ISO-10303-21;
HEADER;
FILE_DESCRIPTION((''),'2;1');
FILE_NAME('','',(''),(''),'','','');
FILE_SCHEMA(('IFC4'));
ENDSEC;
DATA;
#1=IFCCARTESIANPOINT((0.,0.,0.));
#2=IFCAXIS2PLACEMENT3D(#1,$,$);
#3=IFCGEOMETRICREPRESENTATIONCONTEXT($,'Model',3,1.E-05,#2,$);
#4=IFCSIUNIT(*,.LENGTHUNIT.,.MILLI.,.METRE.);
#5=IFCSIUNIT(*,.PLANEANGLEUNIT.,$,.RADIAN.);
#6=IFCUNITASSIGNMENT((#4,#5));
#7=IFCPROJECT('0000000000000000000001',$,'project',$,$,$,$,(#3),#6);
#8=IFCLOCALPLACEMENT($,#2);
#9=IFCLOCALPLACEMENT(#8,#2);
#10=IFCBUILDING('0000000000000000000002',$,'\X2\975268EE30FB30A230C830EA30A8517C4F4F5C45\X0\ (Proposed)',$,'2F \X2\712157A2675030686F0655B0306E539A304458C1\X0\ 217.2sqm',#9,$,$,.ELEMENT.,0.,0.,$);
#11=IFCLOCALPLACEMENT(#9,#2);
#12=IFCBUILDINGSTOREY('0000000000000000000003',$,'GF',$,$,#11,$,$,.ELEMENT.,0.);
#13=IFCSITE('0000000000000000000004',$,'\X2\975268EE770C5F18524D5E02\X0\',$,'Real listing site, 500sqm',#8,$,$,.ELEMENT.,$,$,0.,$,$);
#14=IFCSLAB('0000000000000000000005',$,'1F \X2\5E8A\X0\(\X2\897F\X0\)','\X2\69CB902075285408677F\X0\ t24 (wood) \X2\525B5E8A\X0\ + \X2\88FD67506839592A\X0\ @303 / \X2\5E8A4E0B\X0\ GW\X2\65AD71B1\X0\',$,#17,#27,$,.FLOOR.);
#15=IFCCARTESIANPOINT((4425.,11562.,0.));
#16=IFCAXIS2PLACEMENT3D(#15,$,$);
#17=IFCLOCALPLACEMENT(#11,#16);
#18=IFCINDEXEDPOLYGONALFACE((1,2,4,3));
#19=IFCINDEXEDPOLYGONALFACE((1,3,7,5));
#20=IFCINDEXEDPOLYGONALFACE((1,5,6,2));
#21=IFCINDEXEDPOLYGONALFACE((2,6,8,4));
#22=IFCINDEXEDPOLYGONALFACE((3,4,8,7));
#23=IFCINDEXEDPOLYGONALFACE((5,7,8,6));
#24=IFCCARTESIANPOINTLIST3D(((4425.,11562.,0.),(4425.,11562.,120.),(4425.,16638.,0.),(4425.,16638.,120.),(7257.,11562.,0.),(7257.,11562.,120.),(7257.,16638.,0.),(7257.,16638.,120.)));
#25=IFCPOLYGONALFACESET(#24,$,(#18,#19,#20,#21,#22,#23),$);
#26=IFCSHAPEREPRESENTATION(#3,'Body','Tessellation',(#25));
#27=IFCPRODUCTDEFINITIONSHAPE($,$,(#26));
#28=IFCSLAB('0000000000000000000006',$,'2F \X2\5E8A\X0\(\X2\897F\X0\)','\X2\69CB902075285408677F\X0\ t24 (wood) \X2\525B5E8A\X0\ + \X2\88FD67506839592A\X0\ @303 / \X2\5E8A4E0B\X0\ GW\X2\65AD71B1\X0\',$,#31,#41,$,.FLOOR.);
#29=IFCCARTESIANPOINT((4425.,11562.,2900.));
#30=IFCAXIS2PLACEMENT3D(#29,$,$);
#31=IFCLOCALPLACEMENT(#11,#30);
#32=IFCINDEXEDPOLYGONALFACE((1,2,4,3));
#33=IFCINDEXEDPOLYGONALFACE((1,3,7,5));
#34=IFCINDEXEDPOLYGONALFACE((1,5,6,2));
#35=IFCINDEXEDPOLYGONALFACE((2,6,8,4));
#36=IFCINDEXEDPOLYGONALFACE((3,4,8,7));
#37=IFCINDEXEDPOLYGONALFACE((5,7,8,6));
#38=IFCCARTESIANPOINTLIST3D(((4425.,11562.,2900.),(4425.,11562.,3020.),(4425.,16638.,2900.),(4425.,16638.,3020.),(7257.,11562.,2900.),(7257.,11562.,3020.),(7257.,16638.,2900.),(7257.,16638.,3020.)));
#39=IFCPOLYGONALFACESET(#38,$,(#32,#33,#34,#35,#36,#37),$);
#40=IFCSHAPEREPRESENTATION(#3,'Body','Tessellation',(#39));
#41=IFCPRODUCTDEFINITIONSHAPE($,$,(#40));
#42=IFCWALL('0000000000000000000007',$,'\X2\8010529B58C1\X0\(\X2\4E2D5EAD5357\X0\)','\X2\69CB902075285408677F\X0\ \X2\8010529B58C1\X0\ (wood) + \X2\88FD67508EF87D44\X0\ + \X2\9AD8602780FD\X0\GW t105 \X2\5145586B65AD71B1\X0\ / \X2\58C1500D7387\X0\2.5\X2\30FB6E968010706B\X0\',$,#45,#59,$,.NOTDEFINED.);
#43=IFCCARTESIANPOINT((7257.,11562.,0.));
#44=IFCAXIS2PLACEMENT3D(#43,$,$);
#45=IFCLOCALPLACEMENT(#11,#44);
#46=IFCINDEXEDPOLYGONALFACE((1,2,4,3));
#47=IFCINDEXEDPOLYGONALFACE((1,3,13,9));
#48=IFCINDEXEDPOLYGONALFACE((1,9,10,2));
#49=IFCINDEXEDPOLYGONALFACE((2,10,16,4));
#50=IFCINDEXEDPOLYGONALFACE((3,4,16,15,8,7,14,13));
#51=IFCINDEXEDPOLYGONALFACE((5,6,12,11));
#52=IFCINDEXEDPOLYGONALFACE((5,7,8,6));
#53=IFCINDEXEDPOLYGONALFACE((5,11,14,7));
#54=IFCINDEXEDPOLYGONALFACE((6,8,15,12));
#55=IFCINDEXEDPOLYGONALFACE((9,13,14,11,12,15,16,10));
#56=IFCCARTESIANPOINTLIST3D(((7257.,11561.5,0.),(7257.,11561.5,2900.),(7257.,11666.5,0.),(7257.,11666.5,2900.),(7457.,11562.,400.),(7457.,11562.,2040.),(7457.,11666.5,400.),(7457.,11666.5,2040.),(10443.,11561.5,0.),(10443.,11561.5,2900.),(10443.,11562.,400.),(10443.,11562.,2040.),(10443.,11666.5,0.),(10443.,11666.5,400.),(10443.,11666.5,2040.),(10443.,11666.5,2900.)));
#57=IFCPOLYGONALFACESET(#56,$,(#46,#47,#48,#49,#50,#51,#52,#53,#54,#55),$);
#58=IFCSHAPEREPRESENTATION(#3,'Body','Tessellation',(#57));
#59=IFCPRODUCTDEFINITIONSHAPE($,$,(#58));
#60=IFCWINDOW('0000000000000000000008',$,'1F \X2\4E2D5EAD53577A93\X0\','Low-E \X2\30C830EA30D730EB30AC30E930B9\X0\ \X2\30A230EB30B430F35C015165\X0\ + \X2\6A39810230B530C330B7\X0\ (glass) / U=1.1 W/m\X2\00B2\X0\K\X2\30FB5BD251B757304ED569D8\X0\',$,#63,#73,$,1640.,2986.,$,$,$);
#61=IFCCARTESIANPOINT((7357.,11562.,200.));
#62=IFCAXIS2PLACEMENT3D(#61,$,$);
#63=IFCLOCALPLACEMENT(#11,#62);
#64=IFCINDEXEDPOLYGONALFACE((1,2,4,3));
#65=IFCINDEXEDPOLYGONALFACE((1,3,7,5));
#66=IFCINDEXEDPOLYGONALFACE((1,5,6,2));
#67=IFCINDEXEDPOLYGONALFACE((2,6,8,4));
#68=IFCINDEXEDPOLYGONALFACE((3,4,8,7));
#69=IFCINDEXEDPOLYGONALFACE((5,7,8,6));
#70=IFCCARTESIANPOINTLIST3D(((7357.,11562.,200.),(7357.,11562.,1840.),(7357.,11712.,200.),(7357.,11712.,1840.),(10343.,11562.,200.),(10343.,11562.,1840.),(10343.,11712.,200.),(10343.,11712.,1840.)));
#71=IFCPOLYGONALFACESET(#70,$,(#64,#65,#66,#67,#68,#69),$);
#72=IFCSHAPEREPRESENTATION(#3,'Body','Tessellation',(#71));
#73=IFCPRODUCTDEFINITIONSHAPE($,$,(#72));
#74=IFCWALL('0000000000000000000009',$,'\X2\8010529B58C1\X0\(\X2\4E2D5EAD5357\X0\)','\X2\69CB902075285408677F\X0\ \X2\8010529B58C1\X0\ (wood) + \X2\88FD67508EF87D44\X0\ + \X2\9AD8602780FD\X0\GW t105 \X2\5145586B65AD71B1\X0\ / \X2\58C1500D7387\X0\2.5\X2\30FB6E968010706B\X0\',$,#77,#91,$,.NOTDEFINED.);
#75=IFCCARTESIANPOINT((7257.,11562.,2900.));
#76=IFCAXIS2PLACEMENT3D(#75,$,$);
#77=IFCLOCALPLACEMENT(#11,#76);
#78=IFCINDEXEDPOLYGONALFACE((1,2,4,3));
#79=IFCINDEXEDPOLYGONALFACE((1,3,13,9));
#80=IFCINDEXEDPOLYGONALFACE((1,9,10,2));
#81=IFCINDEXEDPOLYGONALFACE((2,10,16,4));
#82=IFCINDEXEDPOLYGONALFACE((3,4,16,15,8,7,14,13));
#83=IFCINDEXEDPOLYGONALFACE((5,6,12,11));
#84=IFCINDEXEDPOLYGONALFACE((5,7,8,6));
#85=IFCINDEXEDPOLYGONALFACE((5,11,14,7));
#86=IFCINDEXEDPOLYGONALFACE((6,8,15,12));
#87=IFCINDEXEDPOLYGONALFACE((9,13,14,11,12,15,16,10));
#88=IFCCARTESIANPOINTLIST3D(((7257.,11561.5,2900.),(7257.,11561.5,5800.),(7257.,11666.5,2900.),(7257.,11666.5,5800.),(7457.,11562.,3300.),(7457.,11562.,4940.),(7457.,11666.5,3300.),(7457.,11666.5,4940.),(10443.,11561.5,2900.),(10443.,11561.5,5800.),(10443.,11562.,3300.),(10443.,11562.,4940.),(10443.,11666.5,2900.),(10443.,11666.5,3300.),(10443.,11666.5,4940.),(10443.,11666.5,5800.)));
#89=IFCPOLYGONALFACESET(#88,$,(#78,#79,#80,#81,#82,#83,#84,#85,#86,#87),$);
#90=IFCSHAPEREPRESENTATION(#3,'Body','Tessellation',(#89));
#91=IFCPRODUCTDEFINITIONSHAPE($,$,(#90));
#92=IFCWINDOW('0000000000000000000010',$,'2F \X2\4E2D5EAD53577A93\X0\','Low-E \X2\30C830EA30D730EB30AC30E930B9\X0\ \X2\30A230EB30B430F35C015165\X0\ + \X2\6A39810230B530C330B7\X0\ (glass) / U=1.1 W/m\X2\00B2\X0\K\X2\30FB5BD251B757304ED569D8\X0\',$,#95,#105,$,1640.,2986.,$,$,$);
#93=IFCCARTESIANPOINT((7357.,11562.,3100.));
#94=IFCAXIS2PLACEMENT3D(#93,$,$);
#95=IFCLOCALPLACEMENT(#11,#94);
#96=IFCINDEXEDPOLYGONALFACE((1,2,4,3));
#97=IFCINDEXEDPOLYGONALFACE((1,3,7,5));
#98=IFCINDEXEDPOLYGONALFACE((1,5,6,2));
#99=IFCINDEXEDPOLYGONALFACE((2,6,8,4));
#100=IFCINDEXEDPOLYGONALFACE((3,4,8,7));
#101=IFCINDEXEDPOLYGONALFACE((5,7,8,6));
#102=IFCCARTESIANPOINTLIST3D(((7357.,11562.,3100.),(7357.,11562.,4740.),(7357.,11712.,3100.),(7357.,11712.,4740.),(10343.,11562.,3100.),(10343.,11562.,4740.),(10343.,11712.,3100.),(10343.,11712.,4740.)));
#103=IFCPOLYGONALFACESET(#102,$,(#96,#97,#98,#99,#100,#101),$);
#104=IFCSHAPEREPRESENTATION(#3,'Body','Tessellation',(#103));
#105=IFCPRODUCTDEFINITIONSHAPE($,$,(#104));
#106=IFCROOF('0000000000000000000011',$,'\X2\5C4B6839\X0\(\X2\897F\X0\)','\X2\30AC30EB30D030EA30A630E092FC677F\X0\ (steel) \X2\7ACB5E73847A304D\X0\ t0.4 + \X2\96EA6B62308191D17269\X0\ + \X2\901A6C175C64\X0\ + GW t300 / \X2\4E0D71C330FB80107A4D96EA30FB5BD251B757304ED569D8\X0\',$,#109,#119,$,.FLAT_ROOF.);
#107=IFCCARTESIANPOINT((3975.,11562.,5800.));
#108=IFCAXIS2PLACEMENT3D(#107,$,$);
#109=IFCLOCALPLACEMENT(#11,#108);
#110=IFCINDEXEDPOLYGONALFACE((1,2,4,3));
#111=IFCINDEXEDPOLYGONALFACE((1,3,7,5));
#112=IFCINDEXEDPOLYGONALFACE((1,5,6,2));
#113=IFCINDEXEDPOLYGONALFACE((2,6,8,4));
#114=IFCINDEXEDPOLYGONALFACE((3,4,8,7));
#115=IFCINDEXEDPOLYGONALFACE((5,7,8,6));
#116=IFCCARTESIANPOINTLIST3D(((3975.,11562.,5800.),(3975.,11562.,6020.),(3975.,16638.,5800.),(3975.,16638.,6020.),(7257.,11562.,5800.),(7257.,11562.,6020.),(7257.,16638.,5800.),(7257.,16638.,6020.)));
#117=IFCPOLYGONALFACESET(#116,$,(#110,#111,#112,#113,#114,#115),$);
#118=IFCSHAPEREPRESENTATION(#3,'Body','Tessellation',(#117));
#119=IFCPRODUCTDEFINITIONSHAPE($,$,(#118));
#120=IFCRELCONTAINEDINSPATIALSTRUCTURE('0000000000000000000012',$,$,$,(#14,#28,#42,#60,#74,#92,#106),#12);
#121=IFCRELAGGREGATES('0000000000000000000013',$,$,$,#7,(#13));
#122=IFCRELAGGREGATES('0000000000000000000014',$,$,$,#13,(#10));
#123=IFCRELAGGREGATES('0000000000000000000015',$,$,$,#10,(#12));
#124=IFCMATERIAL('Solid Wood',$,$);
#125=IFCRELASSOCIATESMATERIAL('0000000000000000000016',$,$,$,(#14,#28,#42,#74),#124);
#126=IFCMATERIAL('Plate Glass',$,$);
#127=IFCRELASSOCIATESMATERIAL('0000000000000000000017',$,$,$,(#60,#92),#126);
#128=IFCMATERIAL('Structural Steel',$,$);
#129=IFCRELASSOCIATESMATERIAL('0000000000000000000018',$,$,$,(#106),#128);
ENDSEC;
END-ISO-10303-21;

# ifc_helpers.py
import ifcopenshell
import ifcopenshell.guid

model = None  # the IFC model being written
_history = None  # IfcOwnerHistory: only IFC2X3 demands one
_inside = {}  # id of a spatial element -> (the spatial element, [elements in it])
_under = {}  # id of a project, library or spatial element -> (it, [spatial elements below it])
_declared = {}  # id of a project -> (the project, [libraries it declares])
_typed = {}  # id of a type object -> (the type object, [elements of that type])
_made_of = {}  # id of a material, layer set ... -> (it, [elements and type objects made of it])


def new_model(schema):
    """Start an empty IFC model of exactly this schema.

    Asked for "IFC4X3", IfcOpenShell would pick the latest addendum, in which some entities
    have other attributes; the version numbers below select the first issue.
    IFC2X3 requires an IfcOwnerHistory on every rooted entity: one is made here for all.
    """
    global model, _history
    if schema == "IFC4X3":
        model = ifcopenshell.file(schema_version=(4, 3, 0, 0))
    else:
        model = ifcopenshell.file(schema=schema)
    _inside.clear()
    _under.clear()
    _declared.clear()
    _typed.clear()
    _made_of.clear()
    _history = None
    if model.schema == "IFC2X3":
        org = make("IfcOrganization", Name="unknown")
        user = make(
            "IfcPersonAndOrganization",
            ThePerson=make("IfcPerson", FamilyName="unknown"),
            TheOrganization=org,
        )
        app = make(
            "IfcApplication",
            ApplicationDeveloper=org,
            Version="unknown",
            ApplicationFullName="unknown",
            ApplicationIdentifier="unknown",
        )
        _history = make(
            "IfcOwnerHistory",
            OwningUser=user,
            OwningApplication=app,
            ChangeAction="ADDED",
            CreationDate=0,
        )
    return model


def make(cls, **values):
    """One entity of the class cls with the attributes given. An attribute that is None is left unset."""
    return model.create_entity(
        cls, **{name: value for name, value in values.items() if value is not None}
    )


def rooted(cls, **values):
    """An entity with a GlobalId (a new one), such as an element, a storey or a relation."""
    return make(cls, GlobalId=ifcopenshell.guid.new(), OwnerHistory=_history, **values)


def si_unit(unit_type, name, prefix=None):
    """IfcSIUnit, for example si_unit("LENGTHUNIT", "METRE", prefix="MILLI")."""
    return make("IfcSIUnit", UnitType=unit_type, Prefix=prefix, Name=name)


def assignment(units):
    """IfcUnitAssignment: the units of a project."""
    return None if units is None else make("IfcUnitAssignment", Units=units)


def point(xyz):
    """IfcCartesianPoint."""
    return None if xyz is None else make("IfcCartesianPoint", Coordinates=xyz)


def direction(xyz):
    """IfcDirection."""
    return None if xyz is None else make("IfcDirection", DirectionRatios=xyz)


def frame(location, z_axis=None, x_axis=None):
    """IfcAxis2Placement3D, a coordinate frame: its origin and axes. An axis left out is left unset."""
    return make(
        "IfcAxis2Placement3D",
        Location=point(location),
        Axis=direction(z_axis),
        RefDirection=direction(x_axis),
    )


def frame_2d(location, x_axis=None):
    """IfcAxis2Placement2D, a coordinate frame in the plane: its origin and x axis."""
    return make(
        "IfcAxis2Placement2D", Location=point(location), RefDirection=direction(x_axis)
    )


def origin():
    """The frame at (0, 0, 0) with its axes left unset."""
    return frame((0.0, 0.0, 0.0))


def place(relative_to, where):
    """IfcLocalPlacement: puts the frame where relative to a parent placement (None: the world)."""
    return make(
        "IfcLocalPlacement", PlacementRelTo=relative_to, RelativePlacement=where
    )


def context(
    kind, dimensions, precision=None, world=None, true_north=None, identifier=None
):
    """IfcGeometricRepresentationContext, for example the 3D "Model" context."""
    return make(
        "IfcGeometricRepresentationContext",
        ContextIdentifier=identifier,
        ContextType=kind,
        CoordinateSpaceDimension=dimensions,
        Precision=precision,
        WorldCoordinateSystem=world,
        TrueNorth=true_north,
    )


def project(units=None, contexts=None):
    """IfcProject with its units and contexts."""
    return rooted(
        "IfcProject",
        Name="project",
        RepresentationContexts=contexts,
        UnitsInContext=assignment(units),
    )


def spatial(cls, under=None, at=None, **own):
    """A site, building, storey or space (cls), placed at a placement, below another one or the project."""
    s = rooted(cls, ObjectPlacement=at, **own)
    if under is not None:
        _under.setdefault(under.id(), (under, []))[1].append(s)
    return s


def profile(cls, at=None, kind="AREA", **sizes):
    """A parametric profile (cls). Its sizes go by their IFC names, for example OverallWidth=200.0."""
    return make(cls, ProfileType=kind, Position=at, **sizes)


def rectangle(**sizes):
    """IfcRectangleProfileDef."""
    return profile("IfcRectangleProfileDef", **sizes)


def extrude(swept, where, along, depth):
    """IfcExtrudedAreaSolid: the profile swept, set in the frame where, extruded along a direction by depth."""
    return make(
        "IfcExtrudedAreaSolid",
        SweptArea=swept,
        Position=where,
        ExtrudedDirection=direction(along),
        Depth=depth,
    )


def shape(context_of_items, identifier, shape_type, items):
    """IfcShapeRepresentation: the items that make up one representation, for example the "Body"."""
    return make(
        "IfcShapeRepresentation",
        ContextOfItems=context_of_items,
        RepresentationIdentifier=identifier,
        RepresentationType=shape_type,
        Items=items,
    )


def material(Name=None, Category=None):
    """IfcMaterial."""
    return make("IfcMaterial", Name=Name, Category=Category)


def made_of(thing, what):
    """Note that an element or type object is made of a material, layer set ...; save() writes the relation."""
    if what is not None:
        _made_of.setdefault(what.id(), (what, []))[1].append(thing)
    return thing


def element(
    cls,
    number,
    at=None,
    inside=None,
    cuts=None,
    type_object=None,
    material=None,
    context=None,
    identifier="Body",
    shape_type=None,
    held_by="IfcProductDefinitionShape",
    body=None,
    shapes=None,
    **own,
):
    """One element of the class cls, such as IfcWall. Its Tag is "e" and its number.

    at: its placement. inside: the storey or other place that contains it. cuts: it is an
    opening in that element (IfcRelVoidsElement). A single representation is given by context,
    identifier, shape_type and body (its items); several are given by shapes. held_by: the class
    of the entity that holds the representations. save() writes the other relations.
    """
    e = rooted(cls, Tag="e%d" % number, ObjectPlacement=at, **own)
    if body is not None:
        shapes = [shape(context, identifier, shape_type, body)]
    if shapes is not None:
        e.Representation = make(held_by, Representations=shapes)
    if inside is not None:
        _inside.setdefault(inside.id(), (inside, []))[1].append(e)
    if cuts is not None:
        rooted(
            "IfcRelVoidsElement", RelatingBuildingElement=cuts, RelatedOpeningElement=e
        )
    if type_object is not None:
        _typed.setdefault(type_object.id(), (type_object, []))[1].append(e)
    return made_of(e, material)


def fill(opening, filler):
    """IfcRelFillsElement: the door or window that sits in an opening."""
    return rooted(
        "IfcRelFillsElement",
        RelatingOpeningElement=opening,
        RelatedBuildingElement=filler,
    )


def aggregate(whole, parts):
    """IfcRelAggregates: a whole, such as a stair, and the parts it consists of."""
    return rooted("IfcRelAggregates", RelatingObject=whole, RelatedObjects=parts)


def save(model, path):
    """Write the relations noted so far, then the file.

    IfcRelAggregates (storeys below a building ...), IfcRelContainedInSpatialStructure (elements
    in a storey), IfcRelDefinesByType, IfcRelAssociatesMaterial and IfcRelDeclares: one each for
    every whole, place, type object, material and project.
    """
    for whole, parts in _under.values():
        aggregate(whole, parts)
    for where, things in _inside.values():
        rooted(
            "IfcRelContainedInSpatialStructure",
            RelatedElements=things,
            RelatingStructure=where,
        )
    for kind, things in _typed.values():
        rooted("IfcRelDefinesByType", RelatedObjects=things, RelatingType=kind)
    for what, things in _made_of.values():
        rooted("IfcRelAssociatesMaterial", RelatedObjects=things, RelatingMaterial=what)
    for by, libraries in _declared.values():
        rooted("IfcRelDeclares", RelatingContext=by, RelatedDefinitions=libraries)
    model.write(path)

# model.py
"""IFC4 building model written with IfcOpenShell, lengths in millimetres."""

from ifc_helpers import new_model, si_unit, frame, frame_2d, origin, place, context, project, spatial, rectangle, extrude, material, element, fill, save


model = new_model("IFC4")

# Units and contexts
model_context = context("Model", 3, precision=1e-05, world=origin())
ifc_project = project(units=[si_unit("LENGTHUNIT", "METRE", prefix="MILLI"), si_unit("PLANEANGLEUNIT", "RADIAN")], contexts=[model_context])

# Site, building, storey
site_placement = place(None, origin())
site = spatial("IfcSite", under=ifc_project, at=site_placement, Name="青森県弘前市", ObjectType="Real listing site, 500sqm", CompositionType="ELEMENT", RefElevation=0.0)
building_placement = place(site_placement, origin())
building = spatial("IfcBuilding", under=site, at=building_placement, Name="青森・アトリエ兼住居 (Proposed)", ObjectType="2F 無垢材と漆喰の厚い壁 217.2sqm", CompositionType="ELEMENT", ElevationOfRefHeight=0.0, ElevationOfTerrain=0.0)
storey_placement = place(building_placement, origin())
storey = spatial("IfcBuildingStorey", under=building, at=storey_placement, Name="GF", CompositionType="ELEMENT", Elevation=0.0)

# Shared definitions
ifc_material_1 = material(Name="Solid Wood")

# Slabs
slab_1_placement = place(storey_placement, frame((4425.0, 11562.0, 0.0)))
element("IfcSlab", 1, at=slab_1_placement, inside=storey, material=ifc_material_1, Name="1F 床(西)", Description="構造用合板 t24 (wood) 剛床 + 製材根太 @303 / 床下 GW断熱", PredefinedType="FLOOR", context=model_context, shape_type="SweptSolid", body=[
    extrude(rectangle(XDim=2832.0, YDim=5076.0, at=frame_2d((1416.0, 2538.0))), frame((4425.0, 11562.0, 0.0)), (0.0, 0.0, 1.0), 120.0),
])
slab_2_placement = place(storey_placement, frame((4425.0, 11562.0, 2900.0)))
element("IfcSlab", 2, at=slab_2_placement, inside=storey, material=ifc_material_1, Name="2F 床(西)", Description="構造用合板 t24 (wood) 剛床 + 製材根太 @303 / 床下 GW断熱", PredefinedType="FLOOR", context=model_context, shape_type="SweptSolid", body=[
    extrude(rectangle(XDim=2832.0, YDim=5076.0, at=frame_2d((1416.0, 2538.0))), frame((4425.0, 11562.0, 2900.0)), (0.0, 0.0, 1.0), 120.0),
])

# Wall, opening, window
wall_1_placement = place(storey_placement, frame((7257.0, 11562.0, 0.0)))
wall_1 = element("IfcWall", 3, at=wall_1_placement, inside=storey, material=ifc_material_1, Name="耐力壁(中庭南)", Description="構造用合板 耐力壁 (wood) + 製材軸組 + 高性能GW t105 充填断熱 / 壁倍率2.5・準耐火", PredefinedType="NOTDEFINED", context=model_context, shape_type="SweptSolid", body=[
    extrude(rectangle(XDim=3186.0, YDim=105.0, at=frame_2d((1593.0, 52.0))), frame((7257.0, 11562.0, 0.0)), (0.0, 0.0, 1.0), 2900.0),
])
opening_1_placement = place(storey_placement, frame((7357.0, 11562.0, 200.0)))
opening_1 = element("IfcOpeningElement", 4, at=opening_1_placement, cuts=wall_1, PredefinedType="NOTDEFINED", context=model_context, shape_type="SweptSolid", body=[
    extrude(rectangle(XDim=2986.0, YDim=150.0, at=frame_2d((1493.0, 75.0))), frame((7357.0, 11562.0, 200.0)), (0.0, 0.0, 1.0), 1640.0),
])
ifc_material_2 = material(Name="Plate Glass")
window_1_placement = place(storey_placement, frame((7357.0, 11562.0, 200.0)))
window_1 = element("IfcWindow", 5, at=window_1_placement, inside=storey, material=ifc_material_2, Name="1F 中庭南窓", Description="Low-E トリプルガラス アルゴン封入 + 樹脂サッシ (glass) / U=1.1 W/m²K・寒冷地仕様", OverallHeight=1640.0, OverallWidth=2986.0, context=model_context, shape_type="SweptSolid", body=[
    extrude(rectangle(XDim=2986.0, YDim=150.0, at=frame_2d((1493.0, 75.0))), frame((7357.0, 11562.0, 200.0)), (0.0, 0.0, 1.0), 1640.0),
])
fill(opening_1, window_1)

# Wall, opening, window
wall_2_placement = place(storey_placement, frame((7257.0, 11562.0, 2900.0)))
wall_2 = element("IfcWall", 6, at=wall_2_placement, inside=storey, material=ifc_material_1, Name="耐力壁(中庭南)", Description="構造用合板 耐力壁 (wood) + 製材軸組 + 高性能GW t105 充填断熱 / 壁倍率2.5・準耐火", PredefinedType="NOTDEFINED", context=model_context, shape_type="SweptSolid", body=[
    extrude(rectangle(XDim=3186.0, YDim=105.0, at=frame_2d((1593.0, 52.0))), frame((7257.0, 11562.0, 2900.0)), (0.0, 0.0, 1.0), 2900.0),
])
opening_2_placement = place(storey_placement, frame((7357.0, 11562.0, 3100.0)))
opening_2 = element("IfcOpeningElement", 7, at=opening_2_placement, cuts=wall_2, PredefinedType="NOTDEFINED", context=model_context, shape_type="SweptSolid", body=[
    extrude(rectangle(XDim=2986.0, YDim=150.0, at=frame_2d((1493.0, 75.0))), frame((7357.0, 11562.0, 3100.0)), (0.0, 0.0, 1.0), 1640.0),
])
window_2_placement = place(storey_placement, frame((7357.0, 11562.0, 3100.0)))
window_2 = element("IfcWindow", 8, at=window_2_placement, inside=storey, material=ifc_material_2, Name="2F 中庭南窓", Description="Low-E トリプルガラス アルゴン封入 + 樹脂サッシ (glass) / U=1.1 W/m²K・寒冷地仕様", OverallHeight=1640.0, OverallWidth=2986.0, context=model_context, shape_type="SweptSolid", body=[
    extrude(rectangle(XDim=2986.0, YDim=150.0, at=frame_2d((1493.0, 75.0))), frame((7357.0, 11562.0, 3100.0)), (0.0, 0.0, 1.0), 1640.0),
])
fill(opening_2, window_2)

# Roof
ifc_material_3 = material(Name="Structural Steel")
for number, where, name in (
    (9, (3975.0, 11562.0, 5800.0), "屋根(西)"),
):
    element("IfcRoof", number, at=place(storey_placement, frame(where)), inside=storey, material=ifc_material_3, Name=name, Description="ガルバリウム鋼板 (steel) 立平葺き t0.4 + 雪止め金物 + 通気層 + GW t300 / 不燃・耐積雪・寒冷地仕様", PredefinedType="FLAT_ROOF", context=model_context, shape_type="SweptSolid", body=[
        extrude(rectangle(XDim=3282.0, YDim=5076.0, at=frame_2d((1641.0, 2538.0))), frame((3975.0, 11562.0, 5800.0)), (0.0, 0.0, 1.0), 220.0),
    ])

save(model, "model.ifc")
